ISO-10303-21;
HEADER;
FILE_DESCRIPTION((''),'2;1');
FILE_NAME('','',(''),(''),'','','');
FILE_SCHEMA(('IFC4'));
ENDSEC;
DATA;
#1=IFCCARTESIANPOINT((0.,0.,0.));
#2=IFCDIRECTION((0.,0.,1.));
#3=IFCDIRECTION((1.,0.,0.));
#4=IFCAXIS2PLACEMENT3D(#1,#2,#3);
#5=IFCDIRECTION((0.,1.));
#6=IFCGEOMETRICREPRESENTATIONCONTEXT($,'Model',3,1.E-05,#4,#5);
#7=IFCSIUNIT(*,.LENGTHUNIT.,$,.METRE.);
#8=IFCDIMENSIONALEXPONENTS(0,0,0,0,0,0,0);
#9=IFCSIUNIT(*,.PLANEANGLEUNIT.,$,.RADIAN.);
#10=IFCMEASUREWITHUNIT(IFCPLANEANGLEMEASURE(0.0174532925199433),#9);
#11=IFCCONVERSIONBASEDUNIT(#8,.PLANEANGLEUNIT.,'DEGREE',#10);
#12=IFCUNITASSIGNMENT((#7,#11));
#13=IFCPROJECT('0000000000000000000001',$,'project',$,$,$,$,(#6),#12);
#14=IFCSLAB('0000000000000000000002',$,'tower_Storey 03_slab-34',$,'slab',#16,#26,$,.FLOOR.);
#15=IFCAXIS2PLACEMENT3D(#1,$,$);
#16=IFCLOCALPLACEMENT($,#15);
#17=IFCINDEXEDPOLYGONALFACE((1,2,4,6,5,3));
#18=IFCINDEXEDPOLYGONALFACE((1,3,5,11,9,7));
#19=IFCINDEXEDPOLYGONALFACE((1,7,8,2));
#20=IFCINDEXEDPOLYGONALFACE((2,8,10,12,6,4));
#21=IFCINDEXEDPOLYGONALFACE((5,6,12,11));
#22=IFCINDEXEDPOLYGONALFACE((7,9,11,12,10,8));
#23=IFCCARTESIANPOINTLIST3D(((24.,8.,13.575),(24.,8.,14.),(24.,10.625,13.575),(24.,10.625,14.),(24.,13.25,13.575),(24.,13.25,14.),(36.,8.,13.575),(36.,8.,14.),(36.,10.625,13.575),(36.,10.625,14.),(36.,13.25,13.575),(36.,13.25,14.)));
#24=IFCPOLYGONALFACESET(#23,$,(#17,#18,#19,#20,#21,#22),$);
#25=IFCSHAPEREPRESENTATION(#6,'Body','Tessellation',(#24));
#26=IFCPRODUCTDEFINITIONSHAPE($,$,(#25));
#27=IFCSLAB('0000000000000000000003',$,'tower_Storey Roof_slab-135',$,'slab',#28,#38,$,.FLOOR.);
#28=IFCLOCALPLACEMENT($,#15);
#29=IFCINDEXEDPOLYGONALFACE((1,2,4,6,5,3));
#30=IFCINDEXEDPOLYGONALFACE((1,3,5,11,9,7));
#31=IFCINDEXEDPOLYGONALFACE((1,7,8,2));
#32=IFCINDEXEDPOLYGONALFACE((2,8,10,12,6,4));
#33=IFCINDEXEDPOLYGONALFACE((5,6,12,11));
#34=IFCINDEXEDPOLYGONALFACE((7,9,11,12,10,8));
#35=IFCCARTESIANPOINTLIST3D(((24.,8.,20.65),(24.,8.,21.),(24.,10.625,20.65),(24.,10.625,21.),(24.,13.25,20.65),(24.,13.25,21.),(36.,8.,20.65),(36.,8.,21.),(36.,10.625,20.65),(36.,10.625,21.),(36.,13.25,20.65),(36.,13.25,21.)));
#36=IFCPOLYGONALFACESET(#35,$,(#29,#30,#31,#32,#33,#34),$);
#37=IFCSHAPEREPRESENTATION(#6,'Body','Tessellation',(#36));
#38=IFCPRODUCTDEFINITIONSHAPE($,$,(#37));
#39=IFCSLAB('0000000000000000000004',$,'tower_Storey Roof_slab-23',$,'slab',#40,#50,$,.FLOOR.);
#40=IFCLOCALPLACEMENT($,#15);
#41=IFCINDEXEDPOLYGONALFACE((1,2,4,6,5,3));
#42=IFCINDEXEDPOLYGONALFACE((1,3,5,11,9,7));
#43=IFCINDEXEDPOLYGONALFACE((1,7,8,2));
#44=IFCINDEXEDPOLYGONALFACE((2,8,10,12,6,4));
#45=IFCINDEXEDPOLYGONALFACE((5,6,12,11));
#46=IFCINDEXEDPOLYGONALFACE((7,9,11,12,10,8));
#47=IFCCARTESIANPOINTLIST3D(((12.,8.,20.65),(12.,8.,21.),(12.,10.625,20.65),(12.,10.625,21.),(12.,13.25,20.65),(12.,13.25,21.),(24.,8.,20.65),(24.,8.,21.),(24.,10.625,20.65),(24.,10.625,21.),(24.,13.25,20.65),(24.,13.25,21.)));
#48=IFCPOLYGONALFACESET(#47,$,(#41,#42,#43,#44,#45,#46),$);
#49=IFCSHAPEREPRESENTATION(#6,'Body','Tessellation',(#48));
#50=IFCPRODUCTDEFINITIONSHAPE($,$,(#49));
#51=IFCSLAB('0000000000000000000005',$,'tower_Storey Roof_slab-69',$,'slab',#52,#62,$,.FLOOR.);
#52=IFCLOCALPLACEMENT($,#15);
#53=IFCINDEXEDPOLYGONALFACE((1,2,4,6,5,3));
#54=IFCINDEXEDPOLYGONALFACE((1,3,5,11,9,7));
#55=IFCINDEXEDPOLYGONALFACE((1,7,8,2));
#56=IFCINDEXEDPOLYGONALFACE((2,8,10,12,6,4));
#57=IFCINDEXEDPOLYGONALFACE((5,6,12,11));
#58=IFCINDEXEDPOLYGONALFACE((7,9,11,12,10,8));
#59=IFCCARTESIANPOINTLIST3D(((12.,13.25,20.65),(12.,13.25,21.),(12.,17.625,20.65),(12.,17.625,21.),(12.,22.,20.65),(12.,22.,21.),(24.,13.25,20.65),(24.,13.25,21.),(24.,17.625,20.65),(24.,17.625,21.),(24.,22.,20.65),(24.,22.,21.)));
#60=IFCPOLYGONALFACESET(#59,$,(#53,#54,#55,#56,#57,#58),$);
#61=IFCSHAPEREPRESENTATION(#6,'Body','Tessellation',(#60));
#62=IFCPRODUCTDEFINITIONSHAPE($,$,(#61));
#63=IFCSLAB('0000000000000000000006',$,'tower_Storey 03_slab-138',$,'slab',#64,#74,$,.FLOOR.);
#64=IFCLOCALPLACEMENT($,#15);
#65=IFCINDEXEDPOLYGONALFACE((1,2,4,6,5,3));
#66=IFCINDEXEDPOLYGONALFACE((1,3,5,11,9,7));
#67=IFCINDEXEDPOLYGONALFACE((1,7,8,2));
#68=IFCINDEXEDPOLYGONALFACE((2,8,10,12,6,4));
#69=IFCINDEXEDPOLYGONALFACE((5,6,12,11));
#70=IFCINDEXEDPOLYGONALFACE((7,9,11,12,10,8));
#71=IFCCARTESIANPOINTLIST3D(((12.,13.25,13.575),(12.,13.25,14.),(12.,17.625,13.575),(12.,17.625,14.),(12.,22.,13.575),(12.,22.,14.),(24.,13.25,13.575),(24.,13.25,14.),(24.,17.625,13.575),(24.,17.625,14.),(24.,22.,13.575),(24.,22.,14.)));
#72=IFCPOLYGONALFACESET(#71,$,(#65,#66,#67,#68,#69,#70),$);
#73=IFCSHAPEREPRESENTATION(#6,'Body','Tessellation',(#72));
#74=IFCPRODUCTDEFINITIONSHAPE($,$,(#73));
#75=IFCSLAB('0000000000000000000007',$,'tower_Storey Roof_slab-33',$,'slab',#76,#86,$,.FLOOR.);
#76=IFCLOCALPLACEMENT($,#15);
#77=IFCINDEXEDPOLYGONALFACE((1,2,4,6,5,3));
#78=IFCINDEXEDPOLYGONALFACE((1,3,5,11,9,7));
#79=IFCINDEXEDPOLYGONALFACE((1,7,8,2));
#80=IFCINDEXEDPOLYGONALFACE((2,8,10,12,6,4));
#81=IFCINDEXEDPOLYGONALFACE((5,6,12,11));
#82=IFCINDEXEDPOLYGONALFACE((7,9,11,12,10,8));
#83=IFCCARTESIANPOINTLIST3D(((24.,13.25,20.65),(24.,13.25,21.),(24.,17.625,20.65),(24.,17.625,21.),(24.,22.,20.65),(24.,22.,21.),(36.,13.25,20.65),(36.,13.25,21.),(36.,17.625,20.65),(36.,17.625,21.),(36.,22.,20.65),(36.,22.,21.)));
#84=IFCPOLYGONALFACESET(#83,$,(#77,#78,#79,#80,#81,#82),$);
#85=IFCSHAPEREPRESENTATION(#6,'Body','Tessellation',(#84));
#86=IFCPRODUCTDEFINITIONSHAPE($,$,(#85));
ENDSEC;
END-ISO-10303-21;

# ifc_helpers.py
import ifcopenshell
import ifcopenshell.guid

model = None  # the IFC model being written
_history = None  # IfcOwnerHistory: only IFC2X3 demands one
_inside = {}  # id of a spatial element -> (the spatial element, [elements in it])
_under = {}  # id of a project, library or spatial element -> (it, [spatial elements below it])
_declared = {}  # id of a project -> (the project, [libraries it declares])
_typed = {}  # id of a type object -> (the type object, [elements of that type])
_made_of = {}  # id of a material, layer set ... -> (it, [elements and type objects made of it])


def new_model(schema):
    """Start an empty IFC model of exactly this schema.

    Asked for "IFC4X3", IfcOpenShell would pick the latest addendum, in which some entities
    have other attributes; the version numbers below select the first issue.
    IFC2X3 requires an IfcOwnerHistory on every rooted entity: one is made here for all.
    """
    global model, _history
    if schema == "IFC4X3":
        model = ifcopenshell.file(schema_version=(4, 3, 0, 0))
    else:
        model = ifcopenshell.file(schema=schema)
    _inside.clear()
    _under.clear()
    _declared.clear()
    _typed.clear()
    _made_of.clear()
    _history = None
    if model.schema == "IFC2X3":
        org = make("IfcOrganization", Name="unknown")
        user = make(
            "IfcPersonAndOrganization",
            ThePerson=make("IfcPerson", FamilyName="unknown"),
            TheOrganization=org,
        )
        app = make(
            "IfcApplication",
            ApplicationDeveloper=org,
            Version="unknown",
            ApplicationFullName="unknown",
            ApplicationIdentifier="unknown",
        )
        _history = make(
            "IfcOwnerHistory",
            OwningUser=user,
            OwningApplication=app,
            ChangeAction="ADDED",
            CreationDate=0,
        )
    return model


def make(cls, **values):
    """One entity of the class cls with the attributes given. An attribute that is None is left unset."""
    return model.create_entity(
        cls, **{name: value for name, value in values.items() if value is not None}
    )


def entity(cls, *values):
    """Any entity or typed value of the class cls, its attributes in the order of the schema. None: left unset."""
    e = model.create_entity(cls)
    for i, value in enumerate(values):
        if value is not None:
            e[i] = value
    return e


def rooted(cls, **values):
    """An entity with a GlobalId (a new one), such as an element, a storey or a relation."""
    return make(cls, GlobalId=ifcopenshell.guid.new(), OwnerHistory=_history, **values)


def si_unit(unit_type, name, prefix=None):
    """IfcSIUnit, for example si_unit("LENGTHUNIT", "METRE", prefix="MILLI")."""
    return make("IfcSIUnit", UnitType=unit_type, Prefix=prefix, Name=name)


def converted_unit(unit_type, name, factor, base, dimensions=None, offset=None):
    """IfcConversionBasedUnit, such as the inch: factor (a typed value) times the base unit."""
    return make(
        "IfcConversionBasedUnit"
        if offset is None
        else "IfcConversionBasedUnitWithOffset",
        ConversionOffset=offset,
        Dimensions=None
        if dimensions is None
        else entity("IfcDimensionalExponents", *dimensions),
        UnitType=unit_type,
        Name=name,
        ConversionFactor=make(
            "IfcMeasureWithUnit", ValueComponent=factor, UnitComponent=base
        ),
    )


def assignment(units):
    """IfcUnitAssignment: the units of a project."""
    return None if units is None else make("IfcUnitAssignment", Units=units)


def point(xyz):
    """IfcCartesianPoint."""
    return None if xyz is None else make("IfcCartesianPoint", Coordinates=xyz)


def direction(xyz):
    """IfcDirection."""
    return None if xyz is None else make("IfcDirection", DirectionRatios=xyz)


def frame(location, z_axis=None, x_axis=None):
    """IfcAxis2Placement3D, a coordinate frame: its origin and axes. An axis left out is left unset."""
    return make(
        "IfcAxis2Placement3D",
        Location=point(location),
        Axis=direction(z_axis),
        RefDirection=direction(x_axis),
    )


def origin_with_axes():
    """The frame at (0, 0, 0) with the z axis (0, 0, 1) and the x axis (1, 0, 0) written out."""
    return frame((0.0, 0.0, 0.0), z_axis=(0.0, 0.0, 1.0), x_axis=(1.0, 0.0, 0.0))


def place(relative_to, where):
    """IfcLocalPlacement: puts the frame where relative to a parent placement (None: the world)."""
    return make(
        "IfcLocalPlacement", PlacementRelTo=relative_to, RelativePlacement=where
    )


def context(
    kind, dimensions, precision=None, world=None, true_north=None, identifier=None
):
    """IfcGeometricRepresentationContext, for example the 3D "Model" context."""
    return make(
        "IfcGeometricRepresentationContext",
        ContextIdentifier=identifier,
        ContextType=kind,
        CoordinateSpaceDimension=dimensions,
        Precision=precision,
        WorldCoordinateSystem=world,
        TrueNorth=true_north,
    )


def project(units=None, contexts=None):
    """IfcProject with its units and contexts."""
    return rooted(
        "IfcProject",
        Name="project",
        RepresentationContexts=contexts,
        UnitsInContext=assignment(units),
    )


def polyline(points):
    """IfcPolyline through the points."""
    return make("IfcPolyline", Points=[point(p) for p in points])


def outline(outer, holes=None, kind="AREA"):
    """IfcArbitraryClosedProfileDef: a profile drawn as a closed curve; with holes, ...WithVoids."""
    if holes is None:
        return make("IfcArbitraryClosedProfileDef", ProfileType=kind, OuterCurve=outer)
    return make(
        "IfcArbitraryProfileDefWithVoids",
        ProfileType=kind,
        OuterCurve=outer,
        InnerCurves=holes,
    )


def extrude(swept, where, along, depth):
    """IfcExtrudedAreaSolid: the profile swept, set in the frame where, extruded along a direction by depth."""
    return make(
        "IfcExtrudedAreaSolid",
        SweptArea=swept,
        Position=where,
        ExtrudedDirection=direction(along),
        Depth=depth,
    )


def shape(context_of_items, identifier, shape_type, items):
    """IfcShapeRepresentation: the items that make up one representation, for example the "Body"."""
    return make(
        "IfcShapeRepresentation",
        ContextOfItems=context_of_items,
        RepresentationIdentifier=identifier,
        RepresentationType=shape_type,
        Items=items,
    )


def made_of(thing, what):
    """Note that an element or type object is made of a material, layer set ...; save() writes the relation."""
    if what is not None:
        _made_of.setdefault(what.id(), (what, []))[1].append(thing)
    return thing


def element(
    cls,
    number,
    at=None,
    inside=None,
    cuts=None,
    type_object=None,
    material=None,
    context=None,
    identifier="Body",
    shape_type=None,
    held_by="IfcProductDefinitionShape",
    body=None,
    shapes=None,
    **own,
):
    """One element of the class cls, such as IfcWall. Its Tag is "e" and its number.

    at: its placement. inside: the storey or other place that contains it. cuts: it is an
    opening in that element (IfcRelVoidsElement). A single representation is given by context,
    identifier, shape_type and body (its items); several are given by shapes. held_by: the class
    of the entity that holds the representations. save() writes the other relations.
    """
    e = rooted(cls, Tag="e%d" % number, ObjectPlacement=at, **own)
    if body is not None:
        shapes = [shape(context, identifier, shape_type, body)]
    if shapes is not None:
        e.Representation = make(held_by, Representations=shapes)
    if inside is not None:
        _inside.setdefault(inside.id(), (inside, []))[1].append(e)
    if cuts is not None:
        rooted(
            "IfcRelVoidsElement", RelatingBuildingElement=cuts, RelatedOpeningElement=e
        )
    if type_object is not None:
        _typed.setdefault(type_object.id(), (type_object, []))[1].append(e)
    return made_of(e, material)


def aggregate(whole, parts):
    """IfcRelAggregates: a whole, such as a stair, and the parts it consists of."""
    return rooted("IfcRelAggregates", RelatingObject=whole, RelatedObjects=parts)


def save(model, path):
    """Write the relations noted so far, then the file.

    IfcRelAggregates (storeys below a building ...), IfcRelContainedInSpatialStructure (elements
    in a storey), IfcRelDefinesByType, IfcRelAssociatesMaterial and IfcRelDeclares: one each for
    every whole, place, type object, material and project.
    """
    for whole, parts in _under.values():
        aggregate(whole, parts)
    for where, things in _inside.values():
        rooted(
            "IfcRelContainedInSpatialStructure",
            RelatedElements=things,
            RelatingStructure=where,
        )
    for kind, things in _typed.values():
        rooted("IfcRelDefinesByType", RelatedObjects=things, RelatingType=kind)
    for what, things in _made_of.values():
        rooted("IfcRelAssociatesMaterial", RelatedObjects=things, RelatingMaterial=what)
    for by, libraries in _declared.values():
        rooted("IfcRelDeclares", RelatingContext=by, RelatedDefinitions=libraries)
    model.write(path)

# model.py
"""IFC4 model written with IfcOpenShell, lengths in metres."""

from ifc_helpers import new_model, entity, si_unit, converted_unit, direction, frame, origin_with_axes, place, context, project, polyline, outline, extrude, element, save


model = new_model("IFC4")

# Units and contexts
model_context = context("Model", 3, precision=1e-05, world=origin_with_axes(), true_north=direction((0.0, 1.0)))
ifc_project = project(units=[si_unit("LENGTHUNIT", "METRE"), converted_unit("PLANEANGLEUNIT", "DEGREE", entity("IfcPlaneAngleMeasure", 0.0174532925199433), si_unit("PLANEANGLEUNIT", "RADIAN"), dimensions=[0, 0, 0, 0, 0, 0, 0])], contexts=[model_context])

# Shared definitions
placement_1 = place(None, origin_with_axes())
placement_2 = place(placement_1, frame((0.0, 0.0, 14.0), z_axis=(0.0, 0.0, 1.0), x_axis=(1.0, 0.0, 0.0)))

# Shared definitions
placement_3 = place(placement_1, frame((0.0, 0.0, 21.0), z_axis=(0.0, 0.0, 1.0), x_axis=(1.0, 0.0, 0.0)))

# Slabs
slab_1_placement = place(placement_2, frame((30.0, 10.625, -0.425), z_axis=(0.0, 0.0, 1.0), x_axis=(1.0, 0.0, 0.0)))
element("IfcSlab", 1, at=slab_1_placement, Name="tower_Storey 03_slab-34", ObjectType="slab", PredefinedType="FLOOR", context=model_context, body=[
    extrude(outline(polyline([(-6.0, -2.625, 0.0), (6.0, -2.625, 0.0), (6.0, 0.0, 0.0), (6.0, 2.625, 0.0), (-6.0, 2.625, 0.0), (-6.0, 0.0, 0.0), (-6.0, -2.625, 0.0)])), origin_with_axes(), (0.0, 0.0, 1.0), 0.425),
])
for number, where, z_axis, x_axis, name in (
    (2, (30.0, 10.625, -0.35), (0.0, 0.0, 1.0), (1.0, 0.0, 0.0), "tower_Storey Roof_slab-135"),
    (3, (18.0, 10.625, -0.35), (0.0, 0.0, 1.0), (1.0, 0.0, 0.0), "tower_Storey Roof_slab-23"),
):
    element("IfcSlab", number, at=place(placement_3, frame(where, z_axis=z_axis, x_axis=x_axis)), Name=name, ObjectType="slab", PredefinedType="FLOOR", context=model_context, body=[
        extrude(outline(polyline([(-6.0, -2.625, 0.0), (6.0, -2.625, 0.0), (6.0, 0.0, 0.0), (6.0, 2.625, 0.0), (-6.0, 2.625, 0.0), (-6.0, 0.0, 0.0), (-6.0, -2.625, 0.0)])), origin_with_axes(), (0.0, 0.0, 1.0), 0.35),
    ])
slab_2_placement = place(placement_3, frame((18.0, 17.625, -0.35), z_axis=(0.0, 0.0, 1.0), x_axis=(1.0, 0.0, 0.0)))
element("IfcSlab", 4, at=slab_2_placement, Name="tower_Storey Roof_slab-69", ObjectType="slab", PredefinedType="FLOOR", context=model_context, body=[
    extrude(outline(polyline([(-6.0, 0.0, 0.0), (-6.0, -4.375, 0.0), (6.0, -4.375, 0.0), (6.0, 0.0, 0.0), (6.0, 4.375, 0.0), (-6.0, 4.375, 0.0), (-6.0, 0.0, 0.0)])), origin_with_axes(), (0.0, 0.0, 1.0), 0.35),
])
slab_3_placement = place(placement_2, frame((18.0, 17.625, -0.425), z_axis=(0.0, 0.0, 1.0), x_axis=(1.0, 0.0, 0.0)))
element("IfcSlab", 5, at=slab_3_placement, Name="tower_Storey 03_slab-138", ObjectType="slab", PredefinedType="FLOOR", context=model_context, body=[
    extrude(outline(polyline([(-6.0, 0.0, 0.0), (-6.0, -4.375, 0.0), (6.0, -4.375, 0.0), (6.0, 0.0, 0.0), (6.0, 4.375, 0.0), (-6.0, 4.375, 0.0), (-6.0, 0.0, 0.0)])), origin_with_axes(), (0.0, 0.0, 1.0), 0.425),
])
slab_4_placement = place(placement_3, frame((30.0, 17.625, -0.35), z_axis=(0.0, 0.0, 1.0), x_axis=(1.0, 0.0, 0.0)))
element("IfcSlab", 6, at=slab_4_placement, Name="tower_Storey Roof_slab-33", ObjectType="slab", PredefinedType="FLOOR", context=model_context, body=[
    extrude(outline(polyline([(-6.0, 0.0, 0.0), (-6.0, -4.375, 0.0), (6.0, -4.375, 0.0), (6.0, 0.0, 0.0), (6.0, 4.375, 0.0), (-6.0, 4.375, 0.0), (-6.0, 0.0, 0.0)])), origin_with_axes(), (0.0, 0.0, 1.0), 0.35),
])

save(model, "model.ifc")
